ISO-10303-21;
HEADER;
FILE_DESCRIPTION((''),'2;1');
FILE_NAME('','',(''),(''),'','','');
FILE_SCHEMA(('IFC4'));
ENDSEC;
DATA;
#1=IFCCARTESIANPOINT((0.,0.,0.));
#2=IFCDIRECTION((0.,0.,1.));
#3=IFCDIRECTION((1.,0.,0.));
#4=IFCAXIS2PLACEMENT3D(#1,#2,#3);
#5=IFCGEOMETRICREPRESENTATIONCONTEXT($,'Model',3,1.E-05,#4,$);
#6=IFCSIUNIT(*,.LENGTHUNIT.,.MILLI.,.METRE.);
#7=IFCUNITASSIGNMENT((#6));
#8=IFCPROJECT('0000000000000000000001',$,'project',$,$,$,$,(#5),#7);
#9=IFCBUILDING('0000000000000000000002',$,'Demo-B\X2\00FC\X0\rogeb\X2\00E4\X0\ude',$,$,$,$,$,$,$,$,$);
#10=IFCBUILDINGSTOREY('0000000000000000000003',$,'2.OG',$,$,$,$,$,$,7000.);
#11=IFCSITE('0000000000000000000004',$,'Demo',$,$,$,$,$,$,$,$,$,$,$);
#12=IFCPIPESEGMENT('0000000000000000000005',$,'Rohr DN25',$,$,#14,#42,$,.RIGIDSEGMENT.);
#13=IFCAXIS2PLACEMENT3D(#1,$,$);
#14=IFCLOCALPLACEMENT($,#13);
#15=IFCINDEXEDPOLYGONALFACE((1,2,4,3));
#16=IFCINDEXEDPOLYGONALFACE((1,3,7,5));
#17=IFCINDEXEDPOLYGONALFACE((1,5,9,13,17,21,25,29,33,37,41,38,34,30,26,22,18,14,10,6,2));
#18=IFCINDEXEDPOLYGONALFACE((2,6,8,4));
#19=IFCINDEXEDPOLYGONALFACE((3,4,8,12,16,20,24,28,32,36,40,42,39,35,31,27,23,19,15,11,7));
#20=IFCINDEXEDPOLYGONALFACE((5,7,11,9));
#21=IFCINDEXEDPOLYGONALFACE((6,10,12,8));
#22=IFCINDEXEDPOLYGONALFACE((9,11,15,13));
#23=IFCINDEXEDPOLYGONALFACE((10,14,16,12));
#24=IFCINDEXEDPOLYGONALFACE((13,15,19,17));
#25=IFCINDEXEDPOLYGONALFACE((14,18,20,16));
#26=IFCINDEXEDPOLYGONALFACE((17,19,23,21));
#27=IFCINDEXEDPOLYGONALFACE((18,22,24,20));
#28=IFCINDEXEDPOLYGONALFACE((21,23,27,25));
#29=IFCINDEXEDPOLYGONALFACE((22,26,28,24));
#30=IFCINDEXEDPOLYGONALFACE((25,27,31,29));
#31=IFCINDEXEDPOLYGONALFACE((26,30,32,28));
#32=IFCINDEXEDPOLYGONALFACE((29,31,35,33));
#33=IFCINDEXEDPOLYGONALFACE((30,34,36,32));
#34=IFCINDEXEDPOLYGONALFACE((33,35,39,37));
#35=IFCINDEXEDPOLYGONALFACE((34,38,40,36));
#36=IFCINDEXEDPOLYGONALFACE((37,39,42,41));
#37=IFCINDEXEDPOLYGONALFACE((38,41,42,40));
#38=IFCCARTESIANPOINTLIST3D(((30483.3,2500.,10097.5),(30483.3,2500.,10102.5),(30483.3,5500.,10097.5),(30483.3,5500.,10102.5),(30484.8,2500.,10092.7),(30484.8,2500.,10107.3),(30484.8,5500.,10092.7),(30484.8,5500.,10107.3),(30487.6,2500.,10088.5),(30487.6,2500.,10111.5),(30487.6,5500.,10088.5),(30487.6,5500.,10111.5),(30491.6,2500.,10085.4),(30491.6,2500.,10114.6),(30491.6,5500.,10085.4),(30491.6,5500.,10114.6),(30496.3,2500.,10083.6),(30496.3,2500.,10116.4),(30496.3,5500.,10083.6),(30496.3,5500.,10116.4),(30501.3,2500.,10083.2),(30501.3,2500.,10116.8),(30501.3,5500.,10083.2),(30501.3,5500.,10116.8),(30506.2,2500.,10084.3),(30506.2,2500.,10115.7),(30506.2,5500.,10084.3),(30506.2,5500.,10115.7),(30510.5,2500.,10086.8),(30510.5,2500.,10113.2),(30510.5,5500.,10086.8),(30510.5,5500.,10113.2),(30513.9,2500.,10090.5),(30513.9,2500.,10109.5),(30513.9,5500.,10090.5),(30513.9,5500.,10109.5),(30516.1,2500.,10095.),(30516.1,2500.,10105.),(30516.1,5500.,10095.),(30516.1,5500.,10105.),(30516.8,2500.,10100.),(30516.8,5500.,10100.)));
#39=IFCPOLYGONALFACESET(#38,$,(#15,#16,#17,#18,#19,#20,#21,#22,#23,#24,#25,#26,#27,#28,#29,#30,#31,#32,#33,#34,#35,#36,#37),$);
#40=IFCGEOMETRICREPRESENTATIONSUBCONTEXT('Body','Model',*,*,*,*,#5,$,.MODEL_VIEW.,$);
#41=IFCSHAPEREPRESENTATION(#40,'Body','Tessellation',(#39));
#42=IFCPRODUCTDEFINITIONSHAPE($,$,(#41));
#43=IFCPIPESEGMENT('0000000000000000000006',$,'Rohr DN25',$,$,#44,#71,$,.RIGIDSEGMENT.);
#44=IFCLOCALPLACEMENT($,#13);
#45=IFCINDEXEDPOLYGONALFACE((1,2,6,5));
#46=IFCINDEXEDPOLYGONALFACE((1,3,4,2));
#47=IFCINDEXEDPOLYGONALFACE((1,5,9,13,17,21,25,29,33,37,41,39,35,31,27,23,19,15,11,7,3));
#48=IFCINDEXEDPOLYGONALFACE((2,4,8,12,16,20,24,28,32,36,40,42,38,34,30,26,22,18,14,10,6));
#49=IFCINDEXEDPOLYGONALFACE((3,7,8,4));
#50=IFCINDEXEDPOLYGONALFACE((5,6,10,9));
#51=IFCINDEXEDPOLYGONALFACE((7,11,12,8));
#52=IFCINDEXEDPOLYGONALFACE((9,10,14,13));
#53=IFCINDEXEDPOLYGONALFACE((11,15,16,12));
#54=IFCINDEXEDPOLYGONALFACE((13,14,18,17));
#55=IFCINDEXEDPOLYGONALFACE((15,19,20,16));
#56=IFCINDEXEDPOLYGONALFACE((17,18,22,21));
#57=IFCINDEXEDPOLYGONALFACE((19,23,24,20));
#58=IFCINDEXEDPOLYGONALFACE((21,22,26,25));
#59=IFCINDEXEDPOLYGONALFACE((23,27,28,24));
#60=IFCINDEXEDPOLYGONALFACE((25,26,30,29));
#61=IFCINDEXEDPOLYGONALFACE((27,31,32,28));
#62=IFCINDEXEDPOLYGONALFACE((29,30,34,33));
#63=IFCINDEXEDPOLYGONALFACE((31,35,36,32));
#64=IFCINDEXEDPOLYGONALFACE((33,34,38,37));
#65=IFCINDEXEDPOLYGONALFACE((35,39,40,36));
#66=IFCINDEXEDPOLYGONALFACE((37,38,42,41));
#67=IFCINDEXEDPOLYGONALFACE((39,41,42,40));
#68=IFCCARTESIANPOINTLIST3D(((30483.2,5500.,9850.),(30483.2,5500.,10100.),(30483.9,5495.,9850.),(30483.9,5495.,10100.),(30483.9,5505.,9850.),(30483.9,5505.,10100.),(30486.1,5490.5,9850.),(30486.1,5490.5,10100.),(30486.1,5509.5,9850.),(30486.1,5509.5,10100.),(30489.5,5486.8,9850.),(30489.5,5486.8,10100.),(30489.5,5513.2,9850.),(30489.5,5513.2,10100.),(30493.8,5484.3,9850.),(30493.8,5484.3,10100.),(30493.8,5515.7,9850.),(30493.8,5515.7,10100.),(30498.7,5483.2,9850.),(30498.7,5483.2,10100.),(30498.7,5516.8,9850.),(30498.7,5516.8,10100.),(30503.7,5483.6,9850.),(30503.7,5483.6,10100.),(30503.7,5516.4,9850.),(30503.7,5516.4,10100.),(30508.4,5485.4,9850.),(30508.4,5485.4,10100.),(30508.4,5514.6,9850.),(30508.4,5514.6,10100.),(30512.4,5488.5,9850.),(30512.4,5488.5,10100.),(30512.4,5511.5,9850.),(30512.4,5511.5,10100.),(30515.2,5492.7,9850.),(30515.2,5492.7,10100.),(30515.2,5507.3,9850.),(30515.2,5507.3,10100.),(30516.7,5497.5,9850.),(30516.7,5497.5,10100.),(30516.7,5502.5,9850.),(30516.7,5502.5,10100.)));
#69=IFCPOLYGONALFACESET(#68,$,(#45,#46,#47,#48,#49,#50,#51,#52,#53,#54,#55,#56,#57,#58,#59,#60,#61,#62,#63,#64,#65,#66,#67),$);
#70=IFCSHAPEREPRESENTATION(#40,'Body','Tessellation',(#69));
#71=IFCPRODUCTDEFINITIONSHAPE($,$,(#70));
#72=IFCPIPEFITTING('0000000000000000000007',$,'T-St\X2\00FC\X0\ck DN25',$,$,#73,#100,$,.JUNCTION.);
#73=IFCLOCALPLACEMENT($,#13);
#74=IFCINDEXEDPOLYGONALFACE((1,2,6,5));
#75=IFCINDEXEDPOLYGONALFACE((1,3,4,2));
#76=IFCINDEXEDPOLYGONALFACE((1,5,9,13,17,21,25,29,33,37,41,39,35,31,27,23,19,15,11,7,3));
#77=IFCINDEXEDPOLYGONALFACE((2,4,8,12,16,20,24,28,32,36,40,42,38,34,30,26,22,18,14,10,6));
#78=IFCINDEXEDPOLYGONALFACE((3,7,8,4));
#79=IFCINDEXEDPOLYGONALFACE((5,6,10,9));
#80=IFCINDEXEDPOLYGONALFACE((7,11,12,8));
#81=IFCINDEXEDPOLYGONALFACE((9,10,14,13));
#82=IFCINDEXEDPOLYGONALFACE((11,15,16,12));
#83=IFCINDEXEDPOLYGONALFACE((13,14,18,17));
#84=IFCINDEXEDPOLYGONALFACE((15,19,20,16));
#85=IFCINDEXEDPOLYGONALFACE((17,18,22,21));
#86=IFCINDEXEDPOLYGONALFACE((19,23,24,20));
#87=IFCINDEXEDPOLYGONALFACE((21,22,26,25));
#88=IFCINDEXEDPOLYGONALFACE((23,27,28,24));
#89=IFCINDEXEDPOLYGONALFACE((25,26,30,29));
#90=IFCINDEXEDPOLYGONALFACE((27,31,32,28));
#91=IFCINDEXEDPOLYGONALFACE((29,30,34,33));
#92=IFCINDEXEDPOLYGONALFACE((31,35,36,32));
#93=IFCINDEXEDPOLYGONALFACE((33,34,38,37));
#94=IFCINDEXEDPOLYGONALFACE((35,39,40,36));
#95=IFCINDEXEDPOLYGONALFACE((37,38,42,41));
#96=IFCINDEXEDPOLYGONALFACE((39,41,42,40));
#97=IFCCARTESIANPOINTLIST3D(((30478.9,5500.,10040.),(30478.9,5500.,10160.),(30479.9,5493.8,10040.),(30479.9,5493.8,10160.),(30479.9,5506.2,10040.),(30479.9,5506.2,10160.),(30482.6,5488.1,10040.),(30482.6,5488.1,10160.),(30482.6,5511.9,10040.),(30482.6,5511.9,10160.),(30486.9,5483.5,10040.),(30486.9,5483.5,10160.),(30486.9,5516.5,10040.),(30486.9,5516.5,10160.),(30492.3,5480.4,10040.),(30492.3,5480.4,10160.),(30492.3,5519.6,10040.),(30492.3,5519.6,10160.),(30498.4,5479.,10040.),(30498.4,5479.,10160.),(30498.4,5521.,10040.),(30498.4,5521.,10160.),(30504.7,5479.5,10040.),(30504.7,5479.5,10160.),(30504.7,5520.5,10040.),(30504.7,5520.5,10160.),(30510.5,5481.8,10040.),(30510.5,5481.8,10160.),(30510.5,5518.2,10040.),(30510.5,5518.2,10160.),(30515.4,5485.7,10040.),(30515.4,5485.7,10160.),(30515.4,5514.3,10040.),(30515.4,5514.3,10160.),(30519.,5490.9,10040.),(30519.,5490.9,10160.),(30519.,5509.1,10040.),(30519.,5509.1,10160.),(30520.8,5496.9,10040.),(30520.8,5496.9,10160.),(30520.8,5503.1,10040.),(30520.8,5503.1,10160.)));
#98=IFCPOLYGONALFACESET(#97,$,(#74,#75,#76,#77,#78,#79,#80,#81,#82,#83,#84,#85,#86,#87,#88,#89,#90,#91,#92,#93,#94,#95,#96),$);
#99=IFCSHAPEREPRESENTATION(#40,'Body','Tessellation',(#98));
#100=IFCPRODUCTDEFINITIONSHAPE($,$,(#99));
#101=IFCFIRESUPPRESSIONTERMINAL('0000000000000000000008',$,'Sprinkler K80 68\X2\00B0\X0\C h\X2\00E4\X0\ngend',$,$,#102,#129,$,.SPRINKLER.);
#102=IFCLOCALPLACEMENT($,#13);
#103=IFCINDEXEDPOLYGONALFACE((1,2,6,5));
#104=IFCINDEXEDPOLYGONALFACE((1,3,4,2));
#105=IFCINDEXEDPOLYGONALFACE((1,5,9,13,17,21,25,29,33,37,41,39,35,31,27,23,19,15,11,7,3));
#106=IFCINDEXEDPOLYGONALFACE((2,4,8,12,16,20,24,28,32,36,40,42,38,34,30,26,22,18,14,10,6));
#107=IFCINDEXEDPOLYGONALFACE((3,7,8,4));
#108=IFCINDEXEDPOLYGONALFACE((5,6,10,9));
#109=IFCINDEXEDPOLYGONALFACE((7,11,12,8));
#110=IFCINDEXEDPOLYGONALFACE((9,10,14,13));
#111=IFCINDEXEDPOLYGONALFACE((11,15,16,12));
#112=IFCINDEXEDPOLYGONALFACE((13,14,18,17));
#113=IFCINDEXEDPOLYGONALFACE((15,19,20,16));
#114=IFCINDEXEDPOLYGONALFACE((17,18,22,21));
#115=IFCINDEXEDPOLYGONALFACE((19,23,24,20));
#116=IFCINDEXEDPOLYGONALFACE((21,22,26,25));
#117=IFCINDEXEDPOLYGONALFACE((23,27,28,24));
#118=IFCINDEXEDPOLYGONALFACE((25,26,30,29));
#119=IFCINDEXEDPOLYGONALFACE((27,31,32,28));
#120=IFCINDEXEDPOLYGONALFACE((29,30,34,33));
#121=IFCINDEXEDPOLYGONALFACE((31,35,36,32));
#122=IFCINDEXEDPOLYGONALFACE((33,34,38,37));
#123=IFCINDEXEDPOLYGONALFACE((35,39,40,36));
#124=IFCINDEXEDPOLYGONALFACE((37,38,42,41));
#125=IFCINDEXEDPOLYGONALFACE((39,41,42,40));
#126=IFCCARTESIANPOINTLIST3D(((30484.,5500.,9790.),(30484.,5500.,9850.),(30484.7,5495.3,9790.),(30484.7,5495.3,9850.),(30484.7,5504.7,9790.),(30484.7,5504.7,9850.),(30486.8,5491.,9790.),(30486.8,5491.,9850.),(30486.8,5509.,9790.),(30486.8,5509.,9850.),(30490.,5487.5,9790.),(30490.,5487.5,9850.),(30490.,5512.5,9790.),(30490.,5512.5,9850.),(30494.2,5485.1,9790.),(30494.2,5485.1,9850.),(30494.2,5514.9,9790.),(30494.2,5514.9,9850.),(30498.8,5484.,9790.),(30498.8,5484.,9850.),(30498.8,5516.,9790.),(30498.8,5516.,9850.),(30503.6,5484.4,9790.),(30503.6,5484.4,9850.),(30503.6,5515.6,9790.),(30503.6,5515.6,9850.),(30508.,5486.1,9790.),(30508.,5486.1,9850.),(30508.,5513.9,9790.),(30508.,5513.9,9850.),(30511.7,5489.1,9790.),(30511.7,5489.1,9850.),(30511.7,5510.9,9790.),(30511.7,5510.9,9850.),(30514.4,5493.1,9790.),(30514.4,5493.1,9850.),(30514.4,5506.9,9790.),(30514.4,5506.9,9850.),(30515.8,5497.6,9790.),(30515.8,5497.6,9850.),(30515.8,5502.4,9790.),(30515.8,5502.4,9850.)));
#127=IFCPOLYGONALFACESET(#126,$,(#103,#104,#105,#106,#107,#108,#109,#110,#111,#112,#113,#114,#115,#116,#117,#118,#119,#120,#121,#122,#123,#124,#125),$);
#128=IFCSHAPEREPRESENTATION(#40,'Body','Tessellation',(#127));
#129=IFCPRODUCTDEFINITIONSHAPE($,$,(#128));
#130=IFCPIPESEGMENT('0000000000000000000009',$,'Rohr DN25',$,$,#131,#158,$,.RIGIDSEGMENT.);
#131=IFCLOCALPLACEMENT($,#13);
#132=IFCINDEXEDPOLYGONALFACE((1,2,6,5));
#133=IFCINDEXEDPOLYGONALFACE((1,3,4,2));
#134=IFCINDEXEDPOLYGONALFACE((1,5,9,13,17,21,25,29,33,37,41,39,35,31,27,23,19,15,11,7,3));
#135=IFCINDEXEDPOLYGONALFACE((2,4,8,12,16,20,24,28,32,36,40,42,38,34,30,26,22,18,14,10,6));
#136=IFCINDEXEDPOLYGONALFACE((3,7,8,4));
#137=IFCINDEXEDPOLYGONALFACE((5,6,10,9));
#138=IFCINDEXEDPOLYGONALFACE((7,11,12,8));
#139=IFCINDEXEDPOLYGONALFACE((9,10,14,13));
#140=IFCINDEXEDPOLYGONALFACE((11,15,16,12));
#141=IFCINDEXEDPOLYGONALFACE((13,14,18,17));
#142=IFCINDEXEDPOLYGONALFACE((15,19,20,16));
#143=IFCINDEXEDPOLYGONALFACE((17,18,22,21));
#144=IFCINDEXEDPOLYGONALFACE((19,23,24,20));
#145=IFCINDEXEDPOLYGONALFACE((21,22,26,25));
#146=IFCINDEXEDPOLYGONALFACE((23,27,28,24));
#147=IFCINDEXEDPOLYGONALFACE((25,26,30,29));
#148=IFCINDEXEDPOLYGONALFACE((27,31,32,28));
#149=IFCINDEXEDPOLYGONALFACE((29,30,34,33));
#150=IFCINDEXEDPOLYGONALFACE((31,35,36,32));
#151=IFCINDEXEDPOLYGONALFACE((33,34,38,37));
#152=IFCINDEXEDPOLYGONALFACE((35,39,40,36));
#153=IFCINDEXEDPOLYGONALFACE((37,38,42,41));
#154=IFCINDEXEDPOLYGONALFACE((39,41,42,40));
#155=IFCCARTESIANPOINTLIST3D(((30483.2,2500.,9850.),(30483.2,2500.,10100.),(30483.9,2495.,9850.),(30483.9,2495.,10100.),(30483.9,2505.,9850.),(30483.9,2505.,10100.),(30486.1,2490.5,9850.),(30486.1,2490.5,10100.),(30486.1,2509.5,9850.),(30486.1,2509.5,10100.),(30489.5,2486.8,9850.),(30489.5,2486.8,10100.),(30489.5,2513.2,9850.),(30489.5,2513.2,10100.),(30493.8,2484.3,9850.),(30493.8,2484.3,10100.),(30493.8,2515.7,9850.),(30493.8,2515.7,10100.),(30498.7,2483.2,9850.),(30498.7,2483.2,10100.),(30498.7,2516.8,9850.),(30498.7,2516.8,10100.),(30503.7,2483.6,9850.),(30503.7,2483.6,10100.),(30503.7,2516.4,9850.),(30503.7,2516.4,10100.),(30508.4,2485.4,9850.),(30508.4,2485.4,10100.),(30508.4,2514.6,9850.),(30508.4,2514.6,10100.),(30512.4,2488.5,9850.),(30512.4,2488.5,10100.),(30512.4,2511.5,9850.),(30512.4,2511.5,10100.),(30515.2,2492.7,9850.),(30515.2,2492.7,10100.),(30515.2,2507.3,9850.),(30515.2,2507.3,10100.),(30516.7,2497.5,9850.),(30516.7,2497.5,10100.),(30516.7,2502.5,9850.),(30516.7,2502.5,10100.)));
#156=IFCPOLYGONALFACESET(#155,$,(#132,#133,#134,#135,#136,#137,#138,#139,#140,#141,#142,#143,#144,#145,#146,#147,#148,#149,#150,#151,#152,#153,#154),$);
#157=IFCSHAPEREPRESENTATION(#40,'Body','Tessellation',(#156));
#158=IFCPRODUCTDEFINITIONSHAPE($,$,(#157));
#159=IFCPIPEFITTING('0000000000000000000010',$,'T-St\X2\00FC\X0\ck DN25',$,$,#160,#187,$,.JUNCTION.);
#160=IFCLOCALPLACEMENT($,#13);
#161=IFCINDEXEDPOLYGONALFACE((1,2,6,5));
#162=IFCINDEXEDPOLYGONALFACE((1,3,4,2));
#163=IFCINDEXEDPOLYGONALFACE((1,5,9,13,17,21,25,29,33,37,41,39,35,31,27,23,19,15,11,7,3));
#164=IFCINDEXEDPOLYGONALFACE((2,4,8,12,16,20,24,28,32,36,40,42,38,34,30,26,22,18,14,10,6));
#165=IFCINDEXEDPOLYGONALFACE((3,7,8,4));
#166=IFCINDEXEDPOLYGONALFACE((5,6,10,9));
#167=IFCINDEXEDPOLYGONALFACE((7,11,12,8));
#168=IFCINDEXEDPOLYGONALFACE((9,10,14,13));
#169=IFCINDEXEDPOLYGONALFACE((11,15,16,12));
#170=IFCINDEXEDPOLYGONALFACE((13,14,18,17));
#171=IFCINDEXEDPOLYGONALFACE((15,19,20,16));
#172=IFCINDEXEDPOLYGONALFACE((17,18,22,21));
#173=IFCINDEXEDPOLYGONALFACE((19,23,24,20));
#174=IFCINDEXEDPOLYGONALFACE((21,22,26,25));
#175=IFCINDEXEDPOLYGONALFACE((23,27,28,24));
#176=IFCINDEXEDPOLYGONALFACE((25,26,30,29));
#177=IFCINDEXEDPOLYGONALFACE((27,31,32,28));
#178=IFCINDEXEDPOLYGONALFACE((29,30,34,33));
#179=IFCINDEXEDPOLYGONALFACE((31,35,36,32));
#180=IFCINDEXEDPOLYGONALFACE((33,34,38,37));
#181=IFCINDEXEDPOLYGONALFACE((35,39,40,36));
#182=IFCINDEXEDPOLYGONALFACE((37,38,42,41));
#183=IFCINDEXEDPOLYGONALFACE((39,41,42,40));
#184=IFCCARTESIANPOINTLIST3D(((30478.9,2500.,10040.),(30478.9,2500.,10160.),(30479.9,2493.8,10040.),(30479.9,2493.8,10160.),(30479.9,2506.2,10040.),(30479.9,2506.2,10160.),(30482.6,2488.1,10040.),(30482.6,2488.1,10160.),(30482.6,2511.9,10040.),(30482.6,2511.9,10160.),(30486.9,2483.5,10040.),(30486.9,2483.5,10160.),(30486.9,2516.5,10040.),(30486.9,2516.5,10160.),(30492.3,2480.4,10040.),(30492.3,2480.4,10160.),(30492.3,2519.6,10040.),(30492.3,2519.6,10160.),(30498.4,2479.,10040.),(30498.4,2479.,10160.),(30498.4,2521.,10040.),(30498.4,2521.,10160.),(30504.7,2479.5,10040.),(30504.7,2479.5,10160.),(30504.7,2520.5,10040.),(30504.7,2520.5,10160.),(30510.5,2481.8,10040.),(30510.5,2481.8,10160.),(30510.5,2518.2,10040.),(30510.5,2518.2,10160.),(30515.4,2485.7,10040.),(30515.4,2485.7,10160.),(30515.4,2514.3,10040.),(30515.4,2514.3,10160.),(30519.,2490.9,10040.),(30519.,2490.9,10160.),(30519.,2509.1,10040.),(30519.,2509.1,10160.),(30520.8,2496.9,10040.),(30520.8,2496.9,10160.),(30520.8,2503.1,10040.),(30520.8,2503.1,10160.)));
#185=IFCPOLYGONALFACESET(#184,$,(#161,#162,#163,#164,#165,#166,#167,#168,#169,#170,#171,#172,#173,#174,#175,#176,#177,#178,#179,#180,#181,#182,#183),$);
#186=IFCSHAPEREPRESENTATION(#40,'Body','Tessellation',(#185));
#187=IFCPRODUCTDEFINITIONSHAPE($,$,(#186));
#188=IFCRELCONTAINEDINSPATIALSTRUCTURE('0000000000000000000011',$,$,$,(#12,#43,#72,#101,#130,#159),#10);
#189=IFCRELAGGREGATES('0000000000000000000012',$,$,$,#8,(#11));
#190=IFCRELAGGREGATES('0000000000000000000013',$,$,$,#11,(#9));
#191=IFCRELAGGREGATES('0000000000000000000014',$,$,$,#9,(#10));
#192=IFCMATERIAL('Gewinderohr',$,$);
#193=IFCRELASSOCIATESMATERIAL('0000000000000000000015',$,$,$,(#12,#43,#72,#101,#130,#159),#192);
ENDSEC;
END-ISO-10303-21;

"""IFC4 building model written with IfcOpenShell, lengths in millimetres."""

from ifc_helpers import new_model, si_unit, frame, origin_with_axes, place, context, subcontext, project, spatial, circle, extrude, material, element, save


model = new_model("IFC4")

# Units and contexts
model_context = context("Model", 3, precision=1e-05, world=origin_with_axes())
body_context = subcontext(model_context, "Body", "Model", "MODEL_VIEW")
ifc_project = project(units=[si_unit("LENGTHUNIT", "METRE", prefix="MILLI")], contexts=[model_context])

# Site, building, storey
site = spatial("IfcSite", under=ifc_project, Name="Demo")
building = spatial("IfcBuilding", under=site, Name="Demo-Bürogebäude")
storey = spatial("IfcBuildingStorey", under=building, Name="2.OG", Elevation=7000.0)

# Pipe segments
ifc_material_1 = material(Name="Gewinderohr")
pipe_segment_1_placement = place(None, frame((30500.0, 5500.0, 10100.0), z_axis=(0.0, -1.0, 0.0), x_axis=(1.0, 0.0, 0.0)))
element("IfcPipeSegment", 1, at=pipe_segment_1_placement, inside=storey, material=ifc_material_1, Name="Rohr DN25", PredefinedType="RIGIDSEGMENT", context=body_context, shape_type="SweptSolid", body=[
    extrude(circle(Radius=16.9), origin_with_axes(), (0.0, 0.0, 1.0), 3000.0),
])
pipe_segment_2_placement = place(None, frame((30500.0, 5500.0, 10100.0), z_axis=(0.0, 0.0, -1.0), x_axis=(-1.0, 0.0, 0.0)))
element("IfcPipeSegment", 2, at=pipe_segment_2_placement, inside=storey, material=ifc_material_1, Name="Rohr DN25", PredefinedType="RIGIDSEGMENT", context=body_context, shape_type="SweptSolid", body=[
    extrude(circle(Radius=16.9), origin_with_axes(), (0.0, 0.0, 1.0), 250.0),
])

# Pipe fitting
pipe_fitting_1_placement = place(None, frame((30500.0, 5500.0, 10160.0), z_axis=(0.0, 0.0, -1.0), x_axis=(-1.0, 0.0, 0.0)))
element("IfcPipeFitting", 3, at=pipe_fitting_1_placement, inside=storey, material=ifc_material_1, Name="T-Stück DN25", PredefinedType="JUNCTION", context=body_context, shape_type="SweptSolid", body=[
    extrude(circle(Radius=21.1), origin_with_axes(), (0.0, 0.0, 1.0), 120.0),
])

# Fire suppression terminal
fire_suppression_terminal_1_placement = place(None, frame((30500.0, 5500.0, 9850.0), z_axis=(0.0, 0.0, -1.0), x_axis=(-1.0, 0.0, 0.0)))
element("IfcFireSuppressionTerminal", 4, at=fire_suppression_terminal_1_placement, inside=storey, material=ifc_material_1, Name="Sprinkler K80 68°C hängend", PredefinedType="SPRINKLER", context=body_context, shape_type="SweptSolid", body=[
    extrude(circle(Radius=16.0), origin_with_axes(), (0.0, 0.0, 1.0), 60.0),
])

# Pipe segment
pipe_segment_3_placement = place(None, frame((30500.0, 2500.0, 10100.0), z_axis=(0.0, 0.0, -1.0), x_axis=(-1.0, 0.0, 0.0)))
element("IfcPipeSegment", 5, at=pipe_segment_3_placement, inside=storey, material=ifc_material_1, Name="Rohr DN25", PredefinedType="RIGIDSEGMENT", context=body_context, shape_type="SweptSolid", body=[
    extrude(circle(Radius=16.9), origin_with_axes(), (0.0, 0.0, 1.0), 250.0),
])

# Pipe fitting
pipe_fitting_2_placement = place(None, frame((30500.0, 2500.0, 10160.0), z_axis=(0.0, 0.0, -1.0), x_axis=(-1.0, 0.0, 0.0)))
element("IfcPipeFitting", 6, at=pipe_fitting_2_placement, inside=storey, material=ifc_material_1, Name="T-Stück DN25", PredefinedType="JUNCTION", context=body_context, shape_type="SweptSolid", body=[
    extrude(circle(Radius=21.1), origin_with_axes(), (0.0, 0.0, 1.0), 120.0),
])

save(model, "model.ifc")
